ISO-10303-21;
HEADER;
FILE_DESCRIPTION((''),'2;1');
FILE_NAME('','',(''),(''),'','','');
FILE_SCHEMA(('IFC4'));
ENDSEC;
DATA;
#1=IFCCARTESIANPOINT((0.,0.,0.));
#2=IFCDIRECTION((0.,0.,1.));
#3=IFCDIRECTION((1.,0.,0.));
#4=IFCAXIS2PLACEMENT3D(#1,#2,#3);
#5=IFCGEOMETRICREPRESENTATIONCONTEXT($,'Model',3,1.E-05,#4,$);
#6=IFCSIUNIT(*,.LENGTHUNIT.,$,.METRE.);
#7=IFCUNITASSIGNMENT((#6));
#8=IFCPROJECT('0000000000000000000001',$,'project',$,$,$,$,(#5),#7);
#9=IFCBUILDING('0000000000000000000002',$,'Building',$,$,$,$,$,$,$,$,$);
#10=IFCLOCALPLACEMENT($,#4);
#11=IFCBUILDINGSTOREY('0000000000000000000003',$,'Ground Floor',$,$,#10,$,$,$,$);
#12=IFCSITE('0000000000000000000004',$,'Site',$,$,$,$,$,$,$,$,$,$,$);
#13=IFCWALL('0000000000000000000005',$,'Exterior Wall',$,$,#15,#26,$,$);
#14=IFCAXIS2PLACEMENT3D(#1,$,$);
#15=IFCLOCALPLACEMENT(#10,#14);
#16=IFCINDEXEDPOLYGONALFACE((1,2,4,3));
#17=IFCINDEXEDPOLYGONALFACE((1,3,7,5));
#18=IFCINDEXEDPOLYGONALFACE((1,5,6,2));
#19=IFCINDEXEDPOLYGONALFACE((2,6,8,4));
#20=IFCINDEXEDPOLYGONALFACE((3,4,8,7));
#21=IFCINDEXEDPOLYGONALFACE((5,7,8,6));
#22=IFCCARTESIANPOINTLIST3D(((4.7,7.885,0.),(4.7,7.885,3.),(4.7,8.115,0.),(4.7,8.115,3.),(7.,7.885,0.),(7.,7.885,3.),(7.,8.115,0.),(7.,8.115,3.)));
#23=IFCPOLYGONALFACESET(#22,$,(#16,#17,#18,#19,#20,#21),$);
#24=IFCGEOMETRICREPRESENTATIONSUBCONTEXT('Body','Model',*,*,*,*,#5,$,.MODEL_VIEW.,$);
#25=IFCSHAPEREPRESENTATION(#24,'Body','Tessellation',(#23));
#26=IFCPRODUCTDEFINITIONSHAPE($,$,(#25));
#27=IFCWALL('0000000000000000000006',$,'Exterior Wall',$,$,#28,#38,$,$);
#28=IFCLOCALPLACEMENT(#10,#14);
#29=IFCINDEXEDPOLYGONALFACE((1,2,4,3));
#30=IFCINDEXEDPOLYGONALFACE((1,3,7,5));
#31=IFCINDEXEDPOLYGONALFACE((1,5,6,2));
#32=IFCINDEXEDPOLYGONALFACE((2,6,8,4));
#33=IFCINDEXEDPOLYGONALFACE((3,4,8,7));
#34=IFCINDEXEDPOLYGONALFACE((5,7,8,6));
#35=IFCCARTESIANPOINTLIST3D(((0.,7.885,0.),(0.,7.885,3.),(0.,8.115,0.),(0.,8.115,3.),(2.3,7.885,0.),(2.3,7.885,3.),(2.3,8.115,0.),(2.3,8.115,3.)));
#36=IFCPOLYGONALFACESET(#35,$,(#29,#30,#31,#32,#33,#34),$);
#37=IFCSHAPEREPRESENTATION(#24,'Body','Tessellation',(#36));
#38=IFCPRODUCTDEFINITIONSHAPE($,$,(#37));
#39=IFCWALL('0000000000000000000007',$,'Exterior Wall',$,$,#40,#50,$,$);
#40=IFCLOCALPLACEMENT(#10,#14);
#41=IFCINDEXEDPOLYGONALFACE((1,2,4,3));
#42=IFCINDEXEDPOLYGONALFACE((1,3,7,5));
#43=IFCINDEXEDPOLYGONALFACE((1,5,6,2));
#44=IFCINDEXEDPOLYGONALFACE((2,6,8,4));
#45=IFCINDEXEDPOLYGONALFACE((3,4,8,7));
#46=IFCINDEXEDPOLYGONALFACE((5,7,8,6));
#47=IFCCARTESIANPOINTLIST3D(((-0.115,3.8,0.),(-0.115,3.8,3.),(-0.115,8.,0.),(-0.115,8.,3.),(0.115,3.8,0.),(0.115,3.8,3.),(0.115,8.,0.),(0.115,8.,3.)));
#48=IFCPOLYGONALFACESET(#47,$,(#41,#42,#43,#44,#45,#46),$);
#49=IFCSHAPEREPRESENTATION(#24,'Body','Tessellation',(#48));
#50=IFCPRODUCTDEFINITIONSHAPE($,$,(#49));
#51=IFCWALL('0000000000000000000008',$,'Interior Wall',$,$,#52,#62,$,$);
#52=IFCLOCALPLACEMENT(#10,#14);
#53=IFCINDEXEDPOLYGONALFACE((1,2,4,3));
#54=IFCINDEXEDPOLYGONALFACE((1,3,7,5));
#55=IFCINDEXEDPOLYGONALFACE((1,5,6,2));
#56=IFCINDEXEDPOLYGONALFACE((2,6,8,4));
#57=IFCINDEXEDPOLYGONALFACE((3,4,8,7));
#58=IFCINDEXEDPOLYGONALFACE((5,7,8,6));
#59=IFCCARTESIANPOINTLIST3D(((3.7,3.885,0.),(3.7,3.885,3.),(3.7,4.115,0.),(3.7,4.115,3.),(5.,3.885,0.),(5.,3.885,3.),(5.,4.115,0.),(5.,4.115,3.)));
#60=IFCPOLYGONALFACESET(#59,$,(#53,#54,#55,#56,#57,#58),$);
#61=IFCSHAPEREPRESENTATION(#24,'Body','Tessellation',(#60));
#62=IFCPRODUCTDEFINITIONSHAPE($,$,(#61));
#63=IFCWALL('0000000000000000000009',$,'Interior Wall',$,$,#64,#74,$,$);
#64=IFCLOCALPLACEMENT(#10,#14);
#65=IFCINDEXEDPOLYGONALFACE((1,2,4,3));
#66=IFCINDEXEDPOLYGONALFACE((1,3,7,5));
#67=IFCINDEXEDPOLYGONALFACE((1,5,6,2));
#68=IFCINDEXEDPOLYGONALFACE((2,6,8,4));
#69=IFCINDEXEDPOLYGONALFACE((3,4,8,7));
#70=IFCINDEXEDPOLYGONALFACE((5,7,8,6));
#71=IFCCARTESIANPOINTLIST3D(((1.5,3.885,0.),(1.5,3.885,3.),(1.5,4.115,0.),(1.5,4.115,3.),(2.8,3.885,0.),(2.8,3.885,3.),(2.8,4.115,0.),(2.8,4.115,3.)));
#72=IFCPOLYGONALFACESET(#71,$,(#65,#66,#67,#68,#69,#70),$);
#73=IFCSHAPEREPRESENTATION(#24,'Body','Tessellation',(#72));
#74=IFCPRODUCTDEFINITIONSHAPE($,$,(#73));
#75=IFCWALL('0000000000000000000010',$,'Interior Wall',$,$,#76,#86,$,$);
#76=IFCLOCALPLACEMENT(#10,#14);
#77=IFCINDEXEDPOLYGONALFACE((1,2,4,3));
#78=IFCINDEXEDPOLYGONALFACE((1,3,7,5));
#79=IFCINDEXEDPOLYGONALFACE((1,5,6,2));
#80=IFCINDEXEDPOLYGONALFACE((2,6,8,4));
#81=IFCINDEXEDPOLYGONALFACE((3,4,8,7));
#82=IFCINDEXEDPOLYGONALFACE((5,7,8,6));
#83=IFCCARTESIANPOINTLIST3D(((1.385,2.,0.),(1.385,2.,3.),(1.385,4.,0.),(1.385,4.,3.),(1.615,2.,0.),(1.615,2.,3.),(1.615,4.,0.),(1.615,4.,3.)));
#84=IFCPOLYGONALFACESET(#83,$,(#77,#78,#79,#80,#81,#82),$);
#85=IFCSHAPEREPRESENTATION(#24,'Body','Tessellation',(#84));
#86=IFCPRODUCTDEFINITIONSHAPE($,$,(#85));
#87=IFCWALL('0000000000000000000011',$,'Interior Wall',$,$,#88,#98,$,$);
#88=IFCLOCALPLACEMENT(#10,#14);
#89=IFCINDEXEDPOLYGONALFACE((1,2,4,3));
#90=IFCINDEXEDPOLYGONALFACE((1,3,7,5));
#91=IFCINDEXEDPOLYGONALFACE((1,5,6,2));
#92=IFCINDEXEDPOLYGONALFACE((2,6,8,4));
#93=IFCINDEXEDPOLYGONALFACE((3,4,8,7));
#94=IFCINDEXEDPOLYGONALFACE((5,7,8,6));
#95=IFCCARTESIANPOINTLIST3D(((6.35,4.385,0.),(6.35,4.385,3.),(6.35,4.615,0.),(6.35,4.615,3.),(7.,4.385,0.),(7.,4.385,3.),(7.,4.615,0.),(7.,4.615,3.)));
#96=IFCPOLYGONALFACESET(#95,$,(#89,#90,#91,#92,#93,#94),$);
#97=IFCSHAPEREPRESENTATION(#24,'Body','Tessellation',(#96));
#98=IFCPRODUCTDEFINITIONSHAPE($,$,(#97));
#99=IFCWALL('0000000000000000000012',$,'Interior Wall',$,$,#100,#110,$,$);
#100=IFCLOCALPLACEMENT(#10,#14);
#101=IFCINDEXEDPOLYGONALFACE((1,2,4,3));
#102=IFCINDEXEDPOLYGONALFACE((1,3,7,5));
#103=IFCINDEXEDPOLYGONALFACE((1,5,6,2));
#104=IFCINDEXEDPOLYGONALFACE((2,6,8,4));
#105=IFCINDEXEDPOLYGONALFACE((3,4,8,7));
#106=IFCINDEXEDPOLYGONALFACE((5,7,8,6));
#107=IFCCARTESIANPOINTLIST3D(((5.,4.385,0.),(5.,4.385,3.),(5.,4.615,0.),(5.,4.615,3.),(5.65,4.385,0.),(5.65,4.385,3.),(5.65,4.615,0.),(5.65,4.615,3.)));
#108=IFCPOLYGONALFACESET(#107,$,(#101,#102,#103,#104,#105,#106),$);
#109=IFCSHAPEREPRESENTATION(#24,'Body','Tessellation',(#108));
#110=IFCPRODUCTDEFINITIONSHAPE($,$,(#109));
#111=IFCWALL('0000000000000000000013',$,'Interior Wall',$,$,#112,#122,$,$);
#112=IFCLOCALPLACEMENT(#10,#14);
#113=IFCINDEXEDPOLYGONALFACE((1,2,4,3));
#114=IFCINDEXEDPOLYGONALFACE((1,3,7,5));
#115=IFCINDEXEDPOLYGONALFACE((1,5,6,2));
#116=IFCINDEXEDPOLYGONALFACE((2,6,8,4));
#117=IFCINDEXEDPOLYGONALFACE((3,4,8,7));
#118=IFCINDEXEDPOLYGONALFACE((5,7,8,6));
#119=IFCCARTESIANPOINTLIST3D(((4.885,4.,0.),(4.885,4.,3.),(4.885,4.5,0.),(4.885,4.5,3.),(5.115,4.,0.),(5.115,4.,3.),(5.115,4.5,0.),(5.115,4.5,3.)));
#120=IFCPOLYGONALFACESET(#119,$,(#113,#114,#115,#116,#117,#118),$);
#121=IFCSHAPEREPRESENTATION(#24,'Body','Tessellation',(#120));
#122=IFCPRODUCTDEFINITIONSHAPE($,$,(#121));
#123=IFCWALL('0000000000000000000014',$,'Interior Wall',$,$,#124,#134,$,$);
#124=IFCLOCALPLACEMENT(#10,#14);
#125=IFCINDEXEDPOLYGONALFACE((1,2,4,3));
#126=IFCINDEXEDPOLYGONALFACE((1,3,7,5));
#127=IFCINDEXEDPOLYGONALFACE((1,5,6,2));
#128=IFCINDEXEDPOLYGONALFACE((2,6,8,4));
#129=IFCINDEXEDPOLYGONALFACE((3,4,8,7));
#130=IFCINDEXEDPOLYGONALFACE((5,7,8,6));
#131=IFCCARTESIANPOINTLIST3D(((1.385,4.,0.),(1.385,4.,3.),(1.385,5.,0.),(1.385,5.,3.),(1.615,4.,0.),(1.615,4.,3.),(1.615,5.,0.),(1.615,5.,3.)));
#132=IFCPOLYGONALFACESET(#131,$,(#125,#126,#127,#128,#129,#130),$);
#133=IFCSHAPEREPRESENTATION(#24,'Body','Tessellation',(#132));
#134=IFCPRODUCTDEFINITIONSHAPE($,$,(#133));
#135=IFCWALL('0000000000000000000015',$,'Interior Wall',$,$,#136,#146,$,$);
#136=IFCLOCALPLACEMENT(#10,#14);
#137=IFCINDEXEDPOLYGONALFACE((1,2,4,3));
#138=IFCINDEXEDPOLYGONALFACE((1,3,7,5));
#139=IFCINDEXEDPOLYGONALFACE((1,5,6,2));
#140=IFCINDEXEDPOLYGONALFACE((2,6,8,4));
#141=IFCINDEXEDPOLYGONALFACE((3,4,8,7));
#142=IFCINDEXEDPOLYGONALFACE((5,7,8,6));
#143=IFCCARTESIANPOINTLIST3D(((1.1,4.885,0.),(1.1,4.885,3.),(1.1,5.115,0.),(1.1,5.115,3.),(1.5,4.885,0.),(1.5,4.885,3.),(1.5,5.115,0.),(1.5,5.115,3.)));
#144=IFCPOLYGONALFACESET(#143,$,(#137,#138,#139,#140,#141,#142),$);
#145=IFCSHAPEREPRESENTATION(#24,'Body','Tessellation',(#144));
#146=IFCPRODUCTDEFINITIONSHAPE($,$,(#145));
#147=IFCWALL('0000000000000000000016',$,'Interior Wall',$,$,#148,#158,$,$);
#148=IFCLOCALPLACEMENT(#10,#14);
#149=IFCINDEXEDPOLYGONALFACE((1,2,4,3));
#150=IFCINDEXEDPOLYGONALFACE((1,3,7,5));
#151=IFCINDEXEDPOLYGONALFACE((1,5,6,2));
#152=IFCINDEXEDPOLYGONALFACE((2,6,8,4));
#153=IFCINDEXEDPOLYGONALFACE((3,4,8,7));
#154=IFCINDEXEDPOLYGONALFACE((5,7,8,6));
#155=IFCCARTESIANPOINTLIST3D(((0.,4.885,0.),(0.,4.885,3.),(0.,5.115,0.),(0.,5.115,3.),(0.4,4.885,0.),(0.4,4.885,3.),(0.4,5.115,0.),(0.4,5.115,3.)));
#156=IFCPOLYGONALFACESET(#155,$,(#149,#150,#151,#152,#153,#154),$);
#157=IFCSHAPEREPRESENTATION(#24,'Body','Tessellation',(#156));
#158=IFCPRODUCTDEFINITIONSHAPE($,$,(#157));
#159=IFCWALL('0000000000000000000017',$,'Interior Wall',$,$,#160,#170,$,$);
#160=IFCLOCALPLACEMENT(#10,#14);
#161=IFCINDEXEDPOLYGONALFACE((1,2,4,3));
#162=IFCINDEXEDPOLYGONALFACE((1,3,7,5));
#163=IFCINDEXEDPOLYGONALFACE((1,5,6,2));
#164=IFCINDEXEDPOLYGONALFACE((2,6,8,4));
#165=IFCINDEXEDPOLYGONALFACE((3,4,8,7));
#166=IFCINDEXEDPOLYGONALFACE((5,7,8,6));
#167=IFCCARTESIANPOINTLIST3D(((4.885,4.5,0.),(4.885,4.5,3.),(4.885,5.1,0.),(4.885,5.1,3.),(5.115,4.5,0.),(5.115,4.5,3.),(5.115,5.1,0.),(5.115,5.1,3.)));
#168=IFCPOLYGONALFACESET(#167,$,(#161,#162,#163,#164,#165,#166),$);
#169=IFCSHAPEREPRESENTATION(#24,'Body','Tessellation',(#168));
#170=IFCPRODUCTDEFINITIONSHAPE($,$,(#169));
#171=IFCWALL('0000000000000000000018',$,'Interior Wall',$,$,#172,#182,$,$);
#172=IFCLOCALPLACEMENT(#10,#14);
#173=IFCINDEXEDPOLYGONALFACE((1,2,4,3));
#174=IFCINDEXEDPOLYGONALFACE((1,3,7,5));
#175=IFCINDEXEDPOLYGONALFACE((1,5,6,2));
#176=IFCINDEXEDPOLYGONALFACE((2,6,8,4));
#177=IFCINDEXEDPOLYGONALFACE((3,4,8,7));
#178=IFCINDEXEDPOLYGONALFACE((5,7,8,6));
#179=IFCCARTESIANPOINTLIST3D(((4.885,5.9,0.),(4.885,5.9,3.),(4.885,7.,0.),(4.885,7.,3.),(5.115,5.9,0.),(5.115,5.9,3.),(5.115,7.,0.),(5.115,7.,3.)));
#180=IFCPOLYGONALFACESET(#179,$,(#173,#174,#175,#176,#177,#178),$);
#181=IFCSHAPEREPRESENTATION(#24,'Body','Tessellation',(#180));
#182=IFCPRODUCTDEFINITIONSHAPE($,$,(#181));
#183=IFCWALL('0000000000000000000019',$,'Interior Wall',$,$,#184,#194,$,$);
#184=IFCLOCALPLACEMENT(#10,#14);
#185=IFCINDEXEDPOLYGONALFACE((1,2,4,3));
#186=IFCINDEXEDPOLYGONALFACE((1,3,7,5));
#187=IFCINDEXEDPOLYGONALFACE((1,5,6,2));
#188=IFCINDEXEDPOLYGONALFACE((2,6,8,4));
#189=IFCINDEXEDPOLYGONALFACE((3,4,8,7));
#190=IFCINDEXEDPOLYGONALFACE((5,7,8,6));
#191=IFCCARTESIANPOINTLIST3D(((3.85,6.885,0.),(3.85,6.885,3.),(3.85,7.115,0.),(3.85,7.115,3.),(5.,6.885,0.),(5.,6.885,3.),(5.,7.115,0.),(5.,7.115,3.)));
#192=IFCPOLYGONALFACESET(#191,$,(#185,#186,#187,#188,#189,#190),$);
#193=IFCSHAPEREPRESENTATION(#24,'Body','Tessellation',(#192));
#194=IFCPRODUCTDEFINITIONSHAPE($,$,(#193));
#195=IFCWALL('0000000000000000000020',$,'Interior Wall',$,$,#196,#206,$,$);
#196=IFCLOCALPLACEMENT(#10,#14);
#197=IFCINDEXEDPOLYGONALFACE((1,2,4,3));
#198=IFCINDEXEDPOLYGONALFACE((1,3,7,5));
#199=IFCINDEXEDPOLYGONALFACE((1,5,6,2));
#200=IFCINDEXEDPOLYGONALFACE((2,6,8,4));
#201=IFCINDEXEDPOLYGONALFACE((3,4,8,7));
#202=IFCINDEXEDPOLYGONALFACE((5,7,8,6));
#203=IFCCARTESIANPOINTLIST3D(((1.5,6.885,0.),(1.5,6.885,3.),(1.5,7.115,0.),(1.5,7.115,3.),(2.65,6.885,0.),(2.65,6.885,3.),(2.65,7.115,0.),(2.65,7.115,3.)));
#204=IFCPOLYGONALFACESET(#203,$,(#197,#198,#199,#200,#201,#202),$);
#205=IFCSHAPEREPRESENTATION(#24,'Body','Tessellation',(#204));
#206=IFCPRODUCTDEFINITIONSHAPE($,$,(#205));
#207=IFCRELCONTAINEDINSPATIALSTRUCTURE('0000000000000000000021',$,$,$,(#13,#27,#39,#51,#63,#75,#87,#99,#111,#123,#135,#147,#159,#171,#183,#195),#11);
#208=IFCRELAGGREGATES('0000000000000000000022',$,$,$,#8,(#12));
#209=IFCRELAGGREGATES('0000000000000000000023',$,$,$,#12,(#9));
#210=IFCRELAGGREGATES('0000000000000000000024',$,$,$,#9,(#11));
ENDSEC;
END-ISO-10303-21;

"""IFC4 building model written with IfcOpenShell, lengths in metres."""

from ifc_helpers import new_model, si_unit, frame, origin_with_axes, place, context, subcontext, project, spatial, indexed_curve, outline, extrude, element, save


model = new_model("IFC4")

# Units and contexts
model_context = context("Model", 3, precision=1e-05, world=origin_with_axes())
body_context = subcontext(model_context, "Body", "Model", "MODEL_VIEW")
ifc_project = project(units=[si_unit("LENGTHUNIT", "METRE")], contexts=[model_context])

# Site, building, storey
site = spatial("IfcSite", under=ifc_project, Name="Site")
building = spatial("IfcBuilding", under=site, Name="Building")
storey_placement = place(None, origin_with_axes())
storey = spatial("IfcBuildingStorey", under=building, at=storey_placement, Name="Ground Floor")

# Walls
for number, where, z_axis, x_axis, name in (
    (1, (7.0, 8.0, 0.0), (0.0, 0.0, 1.0), (-1.0, 0.0, 0.0), "Exterior Wall"),
    (2, (2.3, 8.0, 0.0), (0.0, 0.0, 1.0), (-1.0, 0.0, 0.0), "Exterior Wall"),
):
    element("IfcWall", number, at=place(storey_placement, frame(where, z_axis=z_axis, x_axis=x_axis)), inside=storey, Name=name, context=body_context, shape_type="SweptSolid", body=[
        extrude(outline(indexed_curve([(0.0, 0.0), (0.0, 0.23), (2.3, 0.23), (2.3, 0.0), (0.0, 0.0)], self_intersect=False)), frame((0.0, -0.115, 0.0), z_axis=(0.0, 0.0, 1.0), x_axis=(1.0, 0.0, 0.0)), (0.0, 0.0, 1.0), 3.0),
    ])
wall_1_placement = place(storey_placement, frame((0.0, 8.0, 0.0), z_axis=(0.0, 0.0, 1.0), x_axis=(0.0, -1.0, 0.0)))
element("IfcWall", 3, at=wall_1_placement, inside=storey, Name="Exterior Wall", context=body_context, shape_type="SweptSolid", body=[
    extrude(outline(indexed_curve([(0.0, 0.0), (0.0, 0.23), (4.2, 0.23), (4.2, 0.0), (0.0, 0.0)], self_intersect=False)), frame((0.0, -0.115, 0.0), z_axis=(0.0, 0.0, 1.0), x_axis=(1.0, 0.0, 0.0)), (0.0, 0.0, 1.0), 3.0),
])
for number, where, z_axis, x_axis, name in (
    (4, (5.0, 4.0, 0.0), (0.0, 0.0, 1.0), (-1.0, 0.0, 0.0), "Interior Wall"),
    (5, (2.8, 4.0, 0.0), (0.0, 0.0, 1.0), (-1.0, 0.0, 0.0), "Interior Wall"),
):
    element("IfcWall", number, at=place(storey_placement, frame(where, z_axis=z_axis, x_axis=x_axis)), inside=storey, Name=name, context=body_context, shape_type="SweptSolid", body=[
        extrude(outline(indexed_curve([(0.0, 0.0), (0.0, 0.23), (1.3, 0.23), (1.3, 0.0), (0.0, 0.0)], self_intersect=False)), frame((0.0, -0.115, 0.0), z_axis=(0.0, 0.0, 1.0), x_axis=(1.0, 0.0, 0.0)), (0.0, 0.0, 1.0), 3.0),
    ])
wall_2_placement = place(storey_placement, frame((1.5, 4.0, 0.0), z_axis=(0.0, 0.0, 1.0), x_axis=(0.0, -1.0, 0.0)))
element("IfcWall", 6, at=wall_2_placement, inside=storey, Name="Interior Wall", context=body_context, shape_type="SweptSolid", body=[
    extrude(outline(indexed_curve([(0.0, 0.0), (0.0, 0.23), (2.0, 0.23), (2.0, 0.0), (0.0, 0.0)], self_intersect=False)), frame((0.0, -0.115, 0.0), z_axis=(0.0, 0.0, 1.0), x_axis=(1.0, 0.0, 0.0)), (0.0, 0.0, 1.0), 3.0),
])
for number, where, z_axis, x_axis, name in (
    (7, (7.0, 4.5, 0.0), (0.0, 0.0, 1.0), (-1.0, 0.0, 0.0), "Interior Wall"),
    (8, (5.65, 4.5, 0.0), (0.0, 0.0, 1.0), (-1.0, 0.0, 0.0), "Interior Wall"),
):
    element("IfcWall", number, at=place(storey_placement, frame(where, z_axis=z_axis, x_axis=x_axis)), inside=storey, Name=name, context=body_context, shape_type="SweptSolid", body=[
        extrude(outline(indexed_curve([(0.0, 0.0), (0.0, 0.23), (0.65, 0.23), (0.65, 0.0), (0.0, 0.0)], self_intersect=False)), frame((0.0, -0.115, 0.0), z_axis=(0.0, 0.0, 1.0), x_axis=(1.0, 0.0, 0.0)), (0.0, 0.0, 1.0), 3.0),
    ])
wall_3_placement = place(storey_placement, frame((5.0, 4.5, 0.0), z_axis=(0.0, 0.0, 1.0), x_axis=(0.0, -1.0, 0.0)))
element("IfcWall", 9, at=wall_3_placement, inside=storey, Name="Interior Wall", context=body_context, shape_type="SweptSolid", body=[
    extrude(outline(indexed_curve([(0.0, 0.0), (0.0, 0.23), (0.5, 0.23), (0.5, 0.0), (0.0, 0.0)], self_intersect=False)), frame((0.0, -0.115, 0.0), z_axis=(0.0, 0.0, 1.0), x_axis=(1.0, 0.0, 0.0)), (0.0, 0.0, 1.0), 3.0),
])
wall_4_placement = place(storey_placement, frame((1.5, 4.0, 0.0), z_axis=(0.0, 0.0, 1.0), x_axis=(0.0, 1.0, 0.0)))
element("IfcWall", 10, at=wall_4_placement, inside=storey, Name="Interior Wall", context=body_context, shape_type="SweptSolid", body=[
    extrude(outline(indexed_curve([(0.0, 0.0), (0.0, 0.23), (1.0, 0.23), (1.0, 0.0), (0.0, 0.0)], self_intersect=False)), frame((0.0, -0.115, 0.0), z_axis=(0.0, 0.0, 1.0), x_axis=(1.0, 0.0, 0.0)), (0.0, 0.0, 1.0), 3.0),
])
for number, where, z_axis, x_axis, name in (
    (11, (1.5, 5.0, 0.0), (0.0, 0.0, 1.0), (-1.0, 0.0, 0.0), "Interior Wall"),
    (12, (0.4, 5.0, 0.0), (0.0, 0.0, 1.0), (-1.0, 0.0, 0.0), "Interior Wall"),
):
    element("IfcWall", number, at=place(storey_placement, frame(where, z_axis=z_axis, x_axis=x_axis)), inside=storey, Name=name, context=body_context, shape_type="SweptSolid", body=[
        extrude(outline(indexed_curve([(0.0, 0.0), (0.0, 0.23), (0.4, 0.23), (0.4, 0.0), (0.0, 0.0)], self_intersect=False)), frame((0.0, -0.115, 0.0), z_axis=(0.0, 0.0, 1.0), x_axis=(1.0, 0.0, 0.0)), (0.0, 0.0, 1.0), 3.0),
    ])
wall_5_placement = place(storey_placement, frame((5.0, 4.5, 0.0), z_axis=(0.0, 0.0, 1.0), x_axis=(0.0, 1.0, 0.0)))
element("IfcWall", 13, at=wall_5_placement, inside=storey, Name="Interior Wall", context=body_context, shape_type="SweptSolid", body=[
    extrude(outline(indexed_curve([(0.0, 0.0), (0.0, 0.23), (0.6, 0.23), (0.6, 0.0), (0.0, 0.0)], self_intersect=False)), frame((0.0, -0.115, 0.0), z_axis=(0.0, 0.0, 1.0), x_axis=(1.0, 0.0, 0.0)), (0.0, 0.0, 1.0), 3.0),
])
wall_6_placement = place(storey_placement, frame((5.0, 5.9, 0.0), z_axis=(0.0, 0.0, 1.0), x_axis=(0.0, 1.0, 0.0)))
element("IfcWall", 14, at=wall_6_placement, inside=storey, Name="Interior Wall", context=body_context, shape_type="SweptSolid", body=[
    extrude(outline(indexed_curve([(0.0, 0.0), (0.0, 0.23), (1.1, 0.23), (1.1, 0.0), (0.0, 0.0)], self_intersect=False)), frame((0.0, -0.115, 0.0), z_axis=(0.0, 0.0, 1.0), x_axis=(1.0, 0.0, 0.0)), (0.0, 0.0, 1.0), 3.0),
])
for number, where, z_axis, x_axis, name in (
    (15, (5.0, 7.0, 0.0), (0.0, 0.0, 1.0), (-1.0, 0.0, 0.0), "Interior Wall"),
    (16, (2.65, 7.0, 0.0), (0.0, 0.0, 1.0), (-1.0, 0.0, 0.0), "Interior Wall"),
):
    element("IfcWall", number, at=place(storey_placement, frame(where, z_axis=z_axis, x_axis=x_axis)), inside=storey, Name=name, context=body_context, shape_type="SweptSolid", body=[
        extrude(outline(indexed_curve([(0.0, 0.0), (0.0, 0.23), (1.15, 0.23), (1.15, 0.0), (0.0, 0.0)], self_intersect=False)), frame((0.0, -0.115, 0.0), z_axis=(0.0, 0.0, 1.0), x_axis=(1.0, 0.0, 0.0)), (0.0, 0.0, 1.0), 3.0),
    ])

save(model, "model.ifc")
